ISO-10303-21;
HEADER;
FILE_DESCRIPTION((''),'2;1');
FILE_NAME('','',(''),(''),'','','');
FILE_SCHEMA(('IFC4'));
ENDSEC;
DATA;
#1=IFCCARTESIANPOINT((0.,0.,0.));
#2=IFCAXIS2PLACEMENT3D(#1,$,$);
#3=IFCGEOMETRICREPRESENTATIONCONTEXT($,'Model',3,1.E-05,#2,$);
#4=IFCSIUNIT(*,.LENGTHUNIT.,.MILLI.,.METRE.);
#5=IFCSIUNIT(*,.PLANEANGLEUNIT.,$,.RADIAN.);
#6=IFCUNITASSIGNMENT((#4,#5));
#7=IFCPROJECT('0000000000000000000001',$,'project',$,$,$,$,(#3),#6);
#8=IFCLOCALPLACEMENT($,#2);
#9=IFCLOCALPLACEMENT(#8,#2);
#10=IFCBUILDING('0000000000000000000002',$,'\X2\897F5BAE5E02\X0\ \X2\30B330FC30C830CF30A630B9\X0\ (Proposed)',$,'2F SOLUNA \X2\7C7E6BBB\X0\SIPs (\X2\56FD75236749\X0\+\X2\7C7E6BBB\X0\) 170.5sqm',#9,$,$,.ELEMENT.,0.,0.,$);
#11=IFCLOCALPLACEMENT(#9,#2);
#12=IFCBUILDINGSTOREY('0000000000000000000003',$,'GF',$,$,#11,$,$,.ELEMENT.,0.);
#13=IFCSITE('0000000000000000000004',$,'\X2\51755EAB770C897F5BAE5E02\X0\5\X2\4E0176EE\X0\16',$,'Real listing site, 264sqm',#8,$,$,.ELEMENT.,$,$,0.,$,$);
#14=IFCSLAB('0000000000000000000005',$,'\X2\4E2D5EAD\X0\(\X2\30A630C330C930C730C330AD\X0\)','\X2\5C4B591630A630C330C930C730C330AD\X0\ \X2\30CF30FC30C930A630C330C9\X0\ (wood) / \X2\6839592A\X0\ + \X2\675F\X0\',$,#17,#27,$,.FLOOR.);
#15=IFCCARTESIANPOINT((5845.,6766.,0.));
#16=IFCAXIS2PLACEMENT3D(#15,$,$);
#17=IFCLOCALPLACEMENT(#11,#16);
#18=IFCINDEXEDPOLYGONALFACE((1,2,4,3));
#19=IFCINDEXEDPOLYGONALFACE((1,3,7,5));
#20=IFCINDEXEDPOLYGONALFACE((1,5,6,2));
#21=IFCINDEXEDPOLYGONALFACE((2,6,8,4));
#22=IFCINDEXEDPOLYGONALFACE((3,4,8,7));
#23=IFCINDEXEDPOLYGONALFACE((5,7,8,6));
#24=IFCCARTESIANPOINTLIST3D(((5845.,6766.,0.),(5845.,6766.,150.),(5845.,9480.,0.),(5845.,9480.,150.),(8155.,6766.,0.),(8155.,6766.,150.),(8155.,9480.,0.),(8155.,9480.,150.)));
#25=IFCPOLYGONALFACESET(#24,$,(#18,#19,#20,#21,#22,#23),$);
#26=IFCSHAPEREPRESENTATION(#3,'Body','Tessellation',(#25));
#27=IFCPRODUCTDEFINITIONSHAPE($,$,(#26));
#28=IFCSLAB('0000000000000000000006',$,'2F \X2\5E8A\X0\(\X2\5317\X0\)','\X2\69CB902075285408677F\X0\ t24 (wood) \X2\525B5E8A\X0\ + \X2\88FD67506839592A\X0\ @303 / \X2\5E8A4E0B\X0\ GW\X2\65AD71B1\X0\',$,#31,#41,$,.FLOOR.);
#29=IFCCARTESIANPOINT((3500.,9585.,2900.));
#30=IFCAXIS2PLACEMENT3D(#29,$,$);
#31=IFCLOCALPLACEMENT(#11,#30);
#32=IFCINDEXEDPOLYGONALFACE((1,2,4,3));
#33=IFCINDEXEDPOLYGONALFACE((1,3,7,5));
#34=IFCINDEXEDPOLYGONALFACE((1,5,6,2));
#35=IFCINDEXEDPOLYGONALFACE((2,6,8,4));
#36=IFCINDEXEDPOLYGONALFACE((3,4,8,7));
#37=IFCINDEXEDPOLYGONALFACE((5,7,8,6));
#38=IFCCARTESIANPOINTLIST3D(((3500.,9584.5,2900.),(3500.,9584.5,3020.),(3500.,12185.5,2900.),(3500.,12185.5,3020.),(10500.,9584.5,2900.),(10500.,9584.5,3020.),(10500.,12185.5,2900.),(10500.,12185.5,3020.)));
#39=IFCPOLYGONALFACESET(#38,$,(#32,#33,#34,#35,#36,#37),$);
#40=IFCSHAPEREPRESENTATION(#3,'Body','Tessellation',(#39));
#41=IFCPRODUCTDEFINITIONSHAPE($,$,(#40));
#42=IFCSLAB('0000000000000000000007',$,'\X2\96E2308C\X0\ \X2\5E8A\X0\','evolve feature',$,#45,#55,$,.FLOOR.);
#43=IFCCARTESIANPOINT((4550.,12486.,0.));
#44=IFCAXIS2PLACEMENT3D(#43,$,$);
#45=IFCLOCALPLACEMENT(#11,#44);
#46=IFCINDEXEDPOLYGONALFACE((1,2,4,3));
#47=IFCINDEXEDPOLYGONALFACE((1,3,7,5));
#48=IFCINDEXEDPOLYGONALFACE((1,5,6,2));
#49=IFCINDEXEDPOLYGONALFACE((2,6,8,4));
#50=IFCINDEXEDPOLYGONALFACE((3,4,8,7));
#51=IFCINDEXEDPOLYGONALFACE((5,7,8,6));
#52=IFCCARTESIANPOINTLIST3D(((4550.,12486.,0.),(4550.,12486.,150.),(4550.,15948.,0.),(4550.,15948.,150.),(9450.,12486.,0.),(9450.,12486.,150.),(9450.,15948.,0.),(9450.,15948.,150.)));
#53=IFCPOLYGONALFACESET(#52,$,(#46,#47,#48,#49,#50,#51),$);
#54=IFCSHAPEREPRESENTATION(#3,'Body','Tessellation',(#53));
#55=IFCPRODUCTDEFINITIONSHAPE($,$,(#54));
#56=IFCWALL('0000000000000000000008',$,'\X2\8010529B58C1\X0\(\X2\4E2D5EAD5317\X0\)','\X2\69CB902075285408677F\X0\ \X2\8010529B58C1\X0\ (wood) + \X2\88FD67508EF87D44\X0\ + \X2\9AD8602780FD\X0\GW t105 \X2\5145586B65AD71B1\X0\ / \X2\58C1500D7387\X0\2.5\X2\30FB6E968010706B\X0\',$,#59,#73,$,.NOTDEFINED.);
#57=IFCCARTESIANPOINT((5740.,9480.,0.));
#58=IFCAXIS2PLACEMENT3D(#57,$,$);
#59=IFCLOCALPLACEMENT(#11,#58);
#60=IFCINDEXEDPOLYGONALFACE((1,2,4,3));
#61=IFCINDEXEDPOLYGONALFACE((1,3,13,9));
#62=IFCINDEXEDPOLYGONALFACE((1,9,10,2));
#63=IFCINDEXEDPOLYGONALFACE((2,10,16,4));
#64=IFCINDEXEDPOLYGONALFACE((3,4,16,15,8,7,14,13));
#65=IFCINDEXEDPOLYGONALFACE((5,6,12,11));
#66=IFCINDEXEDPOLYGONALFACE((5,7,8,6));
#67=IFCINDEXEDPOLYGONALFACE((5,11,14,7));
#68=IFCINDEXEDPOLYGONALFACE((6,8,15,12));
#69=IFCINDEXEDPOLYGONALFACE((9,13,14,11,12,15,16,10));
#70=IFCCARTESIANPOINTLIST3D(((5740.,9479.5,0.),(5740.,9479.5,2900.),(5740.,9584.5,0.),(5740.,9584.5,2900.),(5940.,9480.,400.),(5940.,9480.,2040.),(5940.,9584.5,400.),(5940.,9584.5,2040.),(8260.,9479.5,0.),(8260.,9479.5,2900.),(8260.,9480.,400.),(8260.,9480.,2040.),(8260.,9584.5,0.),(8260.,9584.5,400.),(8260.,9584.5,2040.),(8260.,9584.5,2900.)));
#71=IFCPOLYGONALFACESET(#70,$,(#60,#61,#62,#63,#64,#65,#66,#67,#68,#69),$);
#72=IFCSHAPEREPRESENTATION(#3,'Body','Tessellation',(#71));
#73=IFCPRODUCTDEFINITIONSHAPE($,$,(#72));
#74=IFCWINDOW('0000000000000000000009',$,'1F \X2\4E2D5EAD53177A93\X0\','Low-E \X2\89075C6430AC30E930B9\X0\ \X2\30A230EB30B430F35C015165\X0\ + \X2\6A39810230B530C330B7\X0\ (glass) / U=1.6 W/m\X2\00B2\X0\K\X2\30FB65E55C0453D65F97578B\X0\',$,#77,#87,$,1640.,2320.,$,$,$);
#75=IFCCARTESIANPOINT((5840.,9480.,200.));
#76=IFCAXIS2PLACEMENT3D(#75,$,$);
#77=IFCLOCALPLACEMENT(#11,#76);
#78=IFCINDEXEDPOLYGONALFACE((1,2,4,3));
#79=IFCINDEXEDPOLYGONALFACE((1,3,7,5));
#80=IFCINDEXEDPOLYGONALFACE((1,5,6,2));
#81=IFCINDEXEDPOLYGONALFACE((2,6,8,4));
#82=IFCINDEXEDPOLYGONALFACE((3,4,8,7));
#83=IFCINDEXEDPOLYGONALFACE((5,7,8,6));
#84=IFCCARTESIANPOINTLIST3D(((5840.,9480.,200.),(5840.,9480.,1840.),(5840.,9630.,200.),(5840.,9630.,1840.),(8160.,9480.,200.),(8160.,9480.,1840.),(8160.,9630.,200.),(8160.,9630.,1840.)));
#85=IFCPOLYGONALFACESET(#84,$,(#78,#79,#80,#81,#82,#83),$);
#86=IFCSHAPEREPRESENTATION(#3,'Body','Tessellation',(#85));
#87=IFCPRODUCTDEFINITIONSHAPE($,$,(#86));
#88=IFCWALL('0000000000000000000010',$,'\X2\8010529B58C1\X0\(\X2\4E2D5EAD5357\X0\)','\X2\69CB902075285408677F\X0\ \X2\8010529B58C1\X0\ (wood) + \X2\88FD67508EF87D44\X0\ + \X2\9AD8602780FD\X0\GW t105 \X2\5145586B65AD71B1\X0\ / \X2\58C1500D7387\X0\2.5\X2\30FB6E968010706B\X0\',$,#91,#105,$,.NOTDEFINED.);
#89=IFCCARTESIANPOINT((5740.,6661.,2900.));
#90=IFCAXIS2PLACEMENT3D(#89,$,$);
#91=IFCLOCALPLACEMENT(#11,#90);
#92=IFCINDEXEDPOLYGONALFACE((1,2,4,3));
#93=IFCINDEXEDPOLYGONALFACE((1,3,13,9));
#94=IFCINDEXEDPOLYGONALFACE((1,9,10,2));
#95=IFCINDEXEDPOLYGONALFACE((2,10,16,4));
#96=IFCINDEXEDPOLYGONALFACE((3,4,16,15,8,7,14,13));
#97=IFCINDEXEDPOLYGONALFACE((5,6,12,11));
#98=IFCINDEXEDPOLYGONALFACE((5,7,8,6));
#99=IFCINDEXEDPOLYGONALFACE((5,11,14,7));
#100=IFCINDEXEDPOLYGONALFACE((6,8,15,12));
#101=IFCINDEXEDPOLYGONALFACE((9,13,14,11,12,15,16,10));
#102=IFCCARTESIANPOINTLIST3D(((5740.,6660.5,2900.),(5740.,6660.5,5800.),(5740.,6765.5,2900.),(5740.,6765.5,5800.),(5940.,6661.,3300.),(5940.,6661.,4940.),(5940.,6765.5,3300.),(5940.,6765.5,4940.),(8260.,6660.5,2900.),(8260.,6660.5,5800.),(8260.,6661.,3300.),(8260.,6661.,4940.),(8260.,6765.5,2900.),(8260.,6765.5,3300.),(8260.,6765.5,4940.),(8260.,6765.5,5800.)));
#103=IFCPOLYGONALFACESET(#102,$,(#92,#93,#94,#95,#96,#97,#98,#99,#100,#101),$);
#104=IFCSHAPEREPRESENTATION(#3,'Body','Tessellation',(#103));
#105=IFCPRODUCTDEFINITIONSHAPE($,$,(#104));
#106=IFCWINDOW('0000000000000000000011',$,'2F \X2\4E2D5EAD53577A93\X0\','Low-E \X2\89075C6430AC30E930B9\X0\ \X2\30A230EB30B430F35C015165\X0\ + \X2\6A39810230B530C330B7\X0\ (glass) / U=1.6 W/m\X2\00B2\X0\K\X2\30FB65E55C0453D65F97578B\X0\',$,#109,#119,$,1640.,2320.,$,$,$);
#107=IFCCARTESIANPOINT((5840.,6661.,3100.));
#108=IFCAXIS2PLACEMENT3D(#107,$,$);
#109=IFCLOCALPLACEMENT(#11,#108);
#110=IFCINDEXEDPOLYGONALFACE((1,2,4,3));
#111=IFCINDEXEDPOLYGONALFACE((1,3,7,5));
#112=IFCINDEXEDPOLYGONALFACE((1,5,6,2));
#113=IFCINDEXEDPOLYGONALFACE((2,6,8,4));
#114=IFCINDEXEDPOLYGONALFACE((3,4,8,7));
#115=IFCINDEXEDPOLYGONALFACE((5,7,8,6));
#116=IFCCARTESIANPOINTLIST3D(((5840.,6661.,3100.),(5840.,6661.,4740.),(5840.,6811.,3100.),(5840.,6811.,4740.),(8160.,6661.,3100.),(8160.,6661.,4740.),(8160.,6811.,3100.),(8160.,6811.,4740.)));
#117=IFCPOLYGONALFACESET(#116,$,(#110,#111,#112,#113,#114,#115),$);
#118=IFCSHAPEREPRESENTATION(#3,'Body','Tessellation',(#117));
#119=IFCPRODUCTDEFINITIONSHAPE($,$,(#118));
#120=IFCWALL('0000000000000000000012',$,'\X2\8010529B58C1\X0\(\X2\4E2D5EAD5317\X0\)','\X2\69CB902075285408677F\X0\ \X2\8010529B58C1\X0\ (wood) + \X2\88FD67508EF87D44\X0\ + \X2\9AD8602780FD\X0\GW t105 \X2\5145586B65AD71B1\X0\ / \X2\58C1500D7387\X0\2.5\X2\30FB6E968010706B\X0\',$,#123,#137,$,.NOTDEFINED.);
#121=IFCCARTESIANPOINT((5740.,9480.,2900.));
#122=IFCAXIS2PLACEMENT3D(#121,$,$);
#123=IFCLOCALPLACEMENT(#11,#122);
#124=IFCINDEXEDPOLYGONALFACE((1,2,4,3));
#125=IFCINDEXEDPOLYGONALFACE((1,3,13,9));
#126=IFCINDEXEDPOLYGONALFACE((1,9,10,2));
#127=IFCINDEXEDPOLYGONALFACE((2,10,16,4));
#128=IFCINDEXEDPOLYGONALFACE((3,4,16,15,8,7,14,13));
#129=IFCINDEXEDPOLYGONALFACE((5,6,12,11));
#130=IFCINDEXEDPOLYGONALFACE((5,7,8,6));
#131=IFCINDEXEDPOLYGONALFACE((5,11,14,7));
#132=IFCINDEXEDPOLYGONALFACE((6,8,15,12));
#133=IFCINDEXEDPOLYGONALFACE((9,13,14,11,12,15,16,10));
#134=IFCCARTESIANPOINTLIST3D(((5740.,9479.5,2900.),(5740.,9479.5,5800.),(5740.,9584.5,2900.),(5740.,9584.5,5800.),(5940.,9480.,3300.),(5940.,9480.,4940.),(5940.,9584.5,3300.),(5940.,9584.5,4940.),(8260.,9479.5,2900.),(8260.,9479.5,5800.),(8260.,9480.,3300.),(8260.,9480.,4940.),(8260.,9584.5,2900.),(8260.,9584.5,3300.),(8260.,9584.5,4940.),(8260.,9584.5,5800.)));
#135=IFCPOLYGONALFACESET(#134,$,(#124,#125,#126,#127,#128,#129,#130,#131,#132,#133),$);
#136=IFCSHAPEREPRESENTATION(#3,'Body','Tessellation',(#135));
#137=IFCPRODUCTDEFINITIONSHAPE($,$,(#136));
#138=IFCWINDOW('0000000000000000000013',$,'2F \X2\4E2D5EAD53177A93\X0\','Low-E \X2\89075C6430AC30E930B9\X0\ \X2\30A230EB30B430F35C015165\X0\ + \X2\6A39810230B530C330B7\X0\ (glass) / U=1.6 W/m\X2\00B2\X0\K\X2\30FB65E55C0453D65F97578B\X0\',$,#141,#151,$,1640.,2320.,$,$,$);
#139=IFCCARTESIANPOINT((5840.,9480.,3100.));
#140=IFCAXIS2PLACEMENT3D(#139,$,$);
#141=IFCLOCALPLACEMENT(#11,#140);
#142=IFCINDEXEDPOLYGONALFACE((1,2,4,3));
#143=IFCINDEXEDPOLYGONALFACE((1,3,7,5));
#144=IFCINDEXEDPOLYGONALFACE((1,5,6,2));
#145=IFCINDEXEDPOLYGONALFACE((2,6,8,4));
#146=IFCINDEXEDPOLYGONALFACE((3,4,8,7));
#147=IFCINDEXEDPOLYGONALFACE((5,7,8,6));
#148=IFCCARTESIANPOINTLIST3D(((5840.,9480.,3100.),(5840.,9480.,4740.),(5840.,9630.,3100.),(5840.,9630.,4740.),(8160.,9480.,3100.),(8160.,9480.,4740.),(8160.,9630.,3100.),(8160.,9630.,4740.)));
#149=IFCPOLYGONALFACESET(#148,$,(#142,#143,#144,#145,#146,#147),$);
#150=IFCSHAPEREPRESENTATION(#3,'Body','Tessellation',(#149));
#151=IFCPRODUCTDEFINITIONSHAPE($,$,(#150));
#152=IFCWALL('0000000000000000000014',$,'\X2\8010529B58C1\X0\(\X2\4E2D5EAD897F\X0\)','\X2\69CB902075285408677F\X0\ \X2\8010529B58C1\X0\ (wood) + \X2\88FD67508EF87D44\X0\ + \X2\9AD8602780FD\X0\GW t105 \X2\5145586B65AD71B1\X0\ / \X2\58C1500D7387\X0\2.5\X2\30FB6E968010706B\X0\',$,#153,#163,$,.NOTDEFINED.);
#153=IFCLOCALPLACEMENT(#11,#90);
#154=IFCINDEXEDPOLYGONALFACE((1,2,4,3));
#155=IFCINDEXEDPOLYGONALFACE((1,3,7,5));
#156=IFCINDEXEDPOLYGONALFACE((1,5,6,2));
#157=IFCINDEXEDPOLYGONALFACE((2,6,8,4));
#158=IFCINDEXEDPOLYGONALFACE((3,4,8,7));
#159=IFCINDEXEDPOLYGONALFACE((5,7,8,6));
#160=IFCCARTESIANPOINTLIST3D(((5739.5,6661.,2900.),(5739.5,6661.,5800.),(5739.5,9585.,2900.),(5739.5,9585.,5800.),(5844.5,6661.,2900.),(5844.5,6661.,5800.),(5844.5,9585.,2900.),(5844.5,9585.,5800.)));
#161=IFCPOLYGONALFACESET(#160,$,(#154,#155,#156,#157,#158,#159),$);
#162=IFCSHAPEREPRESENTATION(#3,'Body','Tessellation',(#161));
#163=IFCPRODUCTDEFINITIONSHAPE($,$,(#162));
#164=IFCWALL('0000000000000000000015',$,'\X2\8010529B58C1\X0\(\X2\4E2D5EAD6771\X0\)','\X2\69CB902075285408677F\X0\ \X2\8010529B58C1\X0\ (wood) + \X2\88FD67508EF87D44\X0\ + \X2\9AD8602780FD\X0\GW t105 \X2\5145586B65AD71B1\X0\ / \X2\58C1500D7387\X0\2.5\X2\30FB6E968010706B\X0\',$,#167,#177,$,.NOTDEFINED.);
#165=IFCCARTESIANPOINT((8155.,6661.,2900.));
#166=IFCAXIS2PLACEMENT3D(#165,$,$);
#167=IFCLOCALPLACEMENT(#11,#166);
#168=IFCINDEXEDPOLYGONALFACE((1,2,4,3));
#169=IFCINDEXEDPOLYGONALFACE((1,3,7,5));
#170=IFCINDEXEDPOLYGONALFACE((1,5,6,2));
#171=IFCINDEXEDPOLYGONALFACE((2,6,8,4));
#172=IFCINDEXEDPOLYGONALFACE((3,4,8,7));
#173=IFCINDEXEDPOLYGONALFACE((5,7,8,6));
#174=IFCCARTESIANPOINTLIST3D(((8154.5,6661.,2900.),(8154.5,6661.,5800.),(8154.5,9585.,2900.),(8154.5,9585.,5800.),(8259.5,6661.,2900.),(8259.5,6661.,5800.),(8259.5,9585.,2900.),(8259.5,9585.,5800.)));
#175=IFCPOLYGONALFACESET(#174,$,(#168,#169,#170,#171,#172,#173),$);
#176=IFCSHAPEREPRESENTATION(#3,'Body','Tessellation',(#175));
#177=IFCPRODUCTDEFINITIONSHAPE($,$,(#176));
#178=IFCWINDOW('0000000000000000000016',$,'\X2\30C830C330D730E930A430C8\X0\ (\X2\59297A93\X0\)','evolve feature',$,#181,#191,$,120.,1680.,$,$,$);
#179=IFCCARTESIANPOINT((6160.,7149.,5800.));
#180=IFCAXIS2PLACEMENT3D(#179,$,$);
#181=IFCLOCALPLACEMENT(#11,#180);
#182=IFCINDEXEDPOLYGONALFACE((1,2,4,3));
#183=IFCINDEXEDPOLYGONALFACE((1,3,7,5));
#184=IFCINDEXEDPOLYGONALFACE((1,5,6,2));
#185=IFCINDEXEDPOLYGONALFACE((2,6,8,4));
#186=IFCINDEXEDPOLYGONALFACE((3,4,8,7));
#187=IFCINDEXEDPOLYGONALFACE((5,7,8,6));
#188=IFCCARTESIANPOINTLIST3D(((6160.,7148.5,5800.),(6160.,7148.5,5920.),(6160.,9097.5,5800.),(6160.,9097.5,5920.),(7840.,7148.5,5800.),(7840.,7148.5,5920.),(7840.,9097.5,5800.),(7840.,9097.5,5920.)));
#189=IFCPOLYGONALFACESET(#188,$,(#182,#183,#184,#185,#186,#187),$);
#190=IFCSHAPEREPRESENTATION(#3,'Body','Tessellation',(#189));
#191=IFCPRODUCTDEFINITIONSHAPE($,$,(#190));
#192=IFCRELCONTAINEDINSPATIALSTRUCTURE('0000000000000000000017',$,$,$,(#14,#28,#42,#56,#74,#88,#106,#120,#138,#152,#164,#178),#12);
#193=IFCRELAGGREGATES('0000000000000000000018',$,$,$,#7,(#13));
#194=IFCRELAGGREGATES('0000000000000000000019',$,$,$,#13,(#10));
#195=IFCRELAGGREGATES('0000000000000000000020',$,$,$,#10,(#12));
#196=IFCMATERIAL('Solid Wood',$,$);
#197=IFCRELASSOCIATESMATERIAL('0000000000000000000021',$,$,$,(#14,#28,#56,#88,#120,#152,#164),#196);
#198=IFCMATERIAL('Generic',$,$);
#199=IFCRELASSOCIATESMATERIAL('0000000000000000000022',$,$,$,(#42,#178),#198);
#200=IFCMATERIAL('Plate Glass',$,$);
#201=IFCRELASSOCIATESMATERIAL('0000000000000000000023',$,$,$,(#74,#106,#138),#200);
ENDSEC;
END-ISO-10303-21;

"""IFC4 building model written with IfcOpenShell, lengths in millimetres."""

from ifc_helpers import new_model, si_unit, frame, frame_2d, origin, place, context, project, spatial, rectangle, extrude, material, element, fill, save


model = new_model("IFC4")

# Units and contexts
model_context = context("Model", 3, precision=1e-05, world=origin())
ifc_project = project(units=[si_unit("LENGTHUNIT", "METRE", prefix="MILLI"), si_unit("PLANEANGLEUNIT", "RADIAN")], contexts=[model_context])

# Site, building, storey
site_placement = place(None, origin())
site = spatial("IfcSite", under=ifc_project, at=site_placement, Name="兵庫県西宮市5丁目16", ObjectType="Real listing site, 264sqm", CompositionType="ELEMENT", RefElevation=0.0)
building_placement = place(site_placement, origin())
building = spatial("IfcBuilding", under=site, at=building_placement, Name="西宮市 コートハウス (Proposed)", ObjectType="2F SOLUNA 籾殻SIPs (国産杉+籾殻) 170.5sqm", CompositionType="ELEMENT", ElevationOfRefHeight=0.0, ElevationOfTerrain=0.0)
storey_placement = place(building_placement, origin())
storey = spatial("IfcBuildingStorey", under=building, at=storey_placement, Name="GF", CompositionType="ELEMENT", Elevation=0.0)

# Slabs
ifc_material_1 = material(Name="Solid Wood")
slab_1_placement = place(storey_placement, frame((5845.0, 6766.0, 0.0)))
element("IfcSlab", 1, at=slab_1_placement, inside=storey, material=ifc_material_1, Name="中庭(ウッドデッキ)", Description="屋外ウッドデッキ ハードウッド (wood) / 根太 + 束", PredefinedType="FLOOR", context=model_context, shape_type="SweptSolid", body=[
    extrude(rectangle(XDim=2310.0, YDim=2714.0, at=frame_2d((1155.0, 1357.0))), frame((5845.0, 6766.0, 0.0)), (0.0, 0.0, 1.0), 150.0),
])
slab_2_placement = place(storey_placement, frame((3500.0, 9585.0, 2900.0)))
element("IfcSlab", 2, at=slab_2_placement, inside=storey, material=ifc_material_1, Name="2F 床(北)", Description="構造用合板 t24 (wood) 剛床 + 製材根太 @303 / 床下 GW断熱", PredefinedType="FLOOR", context=model_context, shape_type="SweptSolid", body=[
    extrude(rectangle(XDim=7000.0, YDim=2601.0, at=frame_2d((3500.0, 1300.0))), frame((3500.0, 9585.0, 2900.0)), (0.0, 0.0, 1.0), 120.0),
])
ifc_material_2 = material(Name="Generic")
slab_3_placement = place(storey_placement, frame((4550.0, 12486.0, 0.0)))
element("IfcSlab", 3, at=slab_3_placement, inside=storey, material=ifc_material_2, Name="離れ 床", Description="evolve feature", PredefinedType="FLOOR", context=model_context, shape_type="SweptSolid", body=[
    extrude(rectangle(XDim=4900.0, YDim=3462.0, at=frame_2d((2450.0, 1731.0))), frame((4550.0, 12486.0, 0.0)), (0.0, 0.0, 1.0), 150.0),
])

# Wall, opening, window
wall_1_placement = place(storey_placement, frame((5740.0, 9480.0, 0.0)))
wall_1 = element("IfcWall", 4, at=wall_1_placement, inside=storey, material=ifc_material_1, Name="耐力壁(中庭北)", Description="構造用合板 耐力壁 (wood) + 製材軸組 + 高性能GW t105 充填断熱 / 壁倍率2.5・準耐火", PredefinedType="NOTDEFINED", context=model_context, shape_type="SweptSolid", body=[
    extrude(rectangle(XDim=2520.0, YDim=105.0, at=frame_2d((1260.0, 52.0))), frame((5740.0, 9480.0, 0.0)), (0.0, 0.0, 1.0), 2900.0),
])
opening_1_placement = place(storey_placement, frame((5840.0, 9480.0, 200.0)))
opening_1 = element("IfcOpeningElement", 5, at=opening_1_placement, cuts=wall_1, PredefinedType="NOTDEFINED", context=model_context, shape_type="SweptSolid", body=[
    extrude(rectangle(XDim=2320.0, YDim=150.0, at=frame_2d((1160.0, 75.0))), frame((5840.0, 9480.0, 200.0)), (0.0, 0.0, 1.0), 1640.0),
])
ifc_material_3 = material(Name="Plate Glass")
window_1_placement = place(storey_placement, frame((5840.0, 9480.0, 200.0)))
window_1 = element("IfcWindow", 6, at=window_1_placement, inside=storey, material=ifc_material_3, Name="1F 中庭北窓", Description="Low-E 複層ガラス アルゴン封入 + 樹脂サッシ (glass) / U=1.6 W/m²K・日射取得型", OverallHeight=1640.0, OverallWidth=2320.0, context=model_context, shape_type="SweptSolid", body=[
    extrude(rectangle(XDim=2320.0, YDim=150.0, at=frame_2d((1160.0, 75.0))), frame((5840.0, 9480.0, 200.0)), (0.0, 0.0, 1.0), 1640.0),
])
fill(opening_1, window_1)

# Walls, openings, windows
wall_2_placement = place(storey_placement, frame((5740.0, 6661.0, 2900.0)))
wall_2 = element("IfcWall", 7, at=wall_2_placement, inside=storey, material=ifc_material_1, Name="耐力壁(中庭南)", Description="構造用合板 耐力壁 (wood) + 製材軸組 + 高性能GW t105 充填断熱 / 壁倍率2.5・準耐火", PredefinedType="NOTDEFINED", context=model_context, shape_type="SweptSolid", body=[
    extrude(rectangle(XDim=2520.0, YDim=105.0, at=frame_2d((1260.0, 52.0))), frame((5740.0, 6661.0, 2900.0)), (0.0, 0.0, 1.0), 2900.0),
])
opening_2_placement = place(storey_placement, frame((5840.0, 6661.0, 3100.0)))
opening_2 = element("IfcOpeningElement", 8, at=opening_2_placement, cuts=wall_2, PredefinedType="NOTDEFINED", context=model_context, shape_type="SweptSolid", body=[
    extrude(rectangle(XDim=2320.0, YDim=150.0, at=frame_2d((1160.0, 75.0))), frame((5840.0, 6661.0, 3100.0)), (0.0, 0.0, 1.0), 1640.0),
])
window_2_placement = place(storey_placement, frame((5840.0, 6661.0, 3100.0)))
window_2 = element("IfcWindow", 9, at=window_2_placement, inside=storey, material=ifc_material_3, Name="2F 中庭南窓", Description="Low-E 複層ガラス アルゴン封入 + 樹脂サッシ (glass) / U=1.6 W/m²K・日射取得型", OverallHeight=1640.0, OverallWidth=2320.0, context=model_context, shape_type="SweptSolid", body=[
    extrude(rectangle(XDim=2320.0, YDim=150.0, at=frame_2d((1160.0, 75.0))), frame((5840.0, 6661.0, 3100.0)), (0.0, 0.0, 1.0), 1640.0),
])
fill(opening_2, window_2)
wall_3_placement = place(storey_placement, frame((5740.0, 9480.0, 2900.0)))
wall_3 = element("IfcWall", 10, at=wall_3_placement, inside=storey, material=ifc_material_1, Name="耐力壁(中庭北)", Description="構造用合板 耐力壁 (wood) + 製材軸組 + 高性能GW t105 充填断熱 / 壁倍率2.5・準耐火", PredefinedType="NOTDEFINED", context=model_context, shape_type="SweptSolid", body=[
    extrude(rectangle(XDim=2520.0, YDim=105.0, at=frame_2d((1260.0, 52.0))), frame((5740.0, 9480.0, 2900.0)), (0.0, 0.0, 1.0), 2900.0),
])
opening_3_placement = place(storey_placement, frame((5840.0, 9480.0, 3100.0)))
opening_3 = element("IfcOpeningElement", 11, at=opening_3_placement, cuts=wall_3, PredefinedType="NOTDEFINED", context=model_context, shape_type="SweptSolid", body=[
    extrude(rectangle(XDim=2320.0, YDim=150.0, at=frame_2d((1160.0, 75.0))), frame((5840.0, 9480.0, 3100.0)), (0.0, 0.0, 1.0), 1640.0),
])
window_3_placement = place(storey_placement, frame((5840.0, 9480.0, 3100.0)))
window_3 = element("IfcWindow", 12, at=window_3_placement, inside=storey, material=ifc_material_3, Name="2F 中庭北窓", Description="Low-E 複層ガラス アルゴン封入 + 樹脂サッシ (glass) / U=1.6 W/m²K・日射取得型", OverallHeight=1640.0, OverallWidth=2320.0, context=model_context, shape_type="SweptSolid", body=[
    extrude(rectangle(XDim=2320.0, YDim=150.0, at=frame_2d((1160.0, 75.0))), frame((5840.0, 9480.0, 3100.0)), (0.0, 0.0, 1.0), 1640.0),
])
fill(opening_3, window_3)

# Walls
wall_4_placement = place(storey_placement, frame((5740.0, 6661.0, 2900.0)))
element("IfcWall", 13, at=wall_4_placement, inside=storey, material=ifc_material_1, Name="耐力壁(中庭西)", Description="構造用合板 耐力壁 (wood) + 製材軸組 + 高性能GW t105 充填断熱 / 壁倍率2.5・準耐火", PredefinedType="NOTDEFINED", context=model_context, shape_type="SweptSolid", body=[
    extrude(rectangle(XDim=105.0, YDim=2924.0, at=frame_2d((52.0, 1462.0))), frame((5740.0, 6661.0, 2900.0)), (0.0, 0.0, 1.0), 2900.0),
])
wall_5_placement = place(storey_placement, frame((8155.0, 6661.0, 2900.0)))
element("IfcWall", 14, at=wall_5_placement, inside=storey, material=ifc_material_1, Name="耐力壁(中庭東)", Description="構造用合板 耐力壁 (wood) + 製材軸組 + 高性能GW t105 充填断熱 / 壁倍率2.5・準耐火", PredefinedType="NOTDEFINED", context=model_context, shape_type="SweptSolid", body=[
    extrude(rectangle(XDim=105.0, YDim=2924.0, at=frame_2d((52.0, 1462.0))), frame((8155.0, 6661.0, 2900.0)), (0.0, 0.0, 1.0), 2900.0),
])

# Window
window_4_placement = place(storey_placement, frame((6160.0, 7149.0, 5800.0)))
element("IfcWindow", 15, at=window_4_placement, inside=storey, material=ifc_material_2, Name="トップライト (天窓)", Description="evolve feature", OverallHeight=120.0, OverallWidth=1680.0, context=model_context, shape_type="SweptSolid", body=[
    extrude(rectangle(XDim=1680.0, YDim=1949.0, at=frame_2d((840.0, 974.0))), frame((6160.0, 7149.0, 5800.0)), (0.0, 0.0, 1.0), 120.0),
])

save(model, "model.ifc")
